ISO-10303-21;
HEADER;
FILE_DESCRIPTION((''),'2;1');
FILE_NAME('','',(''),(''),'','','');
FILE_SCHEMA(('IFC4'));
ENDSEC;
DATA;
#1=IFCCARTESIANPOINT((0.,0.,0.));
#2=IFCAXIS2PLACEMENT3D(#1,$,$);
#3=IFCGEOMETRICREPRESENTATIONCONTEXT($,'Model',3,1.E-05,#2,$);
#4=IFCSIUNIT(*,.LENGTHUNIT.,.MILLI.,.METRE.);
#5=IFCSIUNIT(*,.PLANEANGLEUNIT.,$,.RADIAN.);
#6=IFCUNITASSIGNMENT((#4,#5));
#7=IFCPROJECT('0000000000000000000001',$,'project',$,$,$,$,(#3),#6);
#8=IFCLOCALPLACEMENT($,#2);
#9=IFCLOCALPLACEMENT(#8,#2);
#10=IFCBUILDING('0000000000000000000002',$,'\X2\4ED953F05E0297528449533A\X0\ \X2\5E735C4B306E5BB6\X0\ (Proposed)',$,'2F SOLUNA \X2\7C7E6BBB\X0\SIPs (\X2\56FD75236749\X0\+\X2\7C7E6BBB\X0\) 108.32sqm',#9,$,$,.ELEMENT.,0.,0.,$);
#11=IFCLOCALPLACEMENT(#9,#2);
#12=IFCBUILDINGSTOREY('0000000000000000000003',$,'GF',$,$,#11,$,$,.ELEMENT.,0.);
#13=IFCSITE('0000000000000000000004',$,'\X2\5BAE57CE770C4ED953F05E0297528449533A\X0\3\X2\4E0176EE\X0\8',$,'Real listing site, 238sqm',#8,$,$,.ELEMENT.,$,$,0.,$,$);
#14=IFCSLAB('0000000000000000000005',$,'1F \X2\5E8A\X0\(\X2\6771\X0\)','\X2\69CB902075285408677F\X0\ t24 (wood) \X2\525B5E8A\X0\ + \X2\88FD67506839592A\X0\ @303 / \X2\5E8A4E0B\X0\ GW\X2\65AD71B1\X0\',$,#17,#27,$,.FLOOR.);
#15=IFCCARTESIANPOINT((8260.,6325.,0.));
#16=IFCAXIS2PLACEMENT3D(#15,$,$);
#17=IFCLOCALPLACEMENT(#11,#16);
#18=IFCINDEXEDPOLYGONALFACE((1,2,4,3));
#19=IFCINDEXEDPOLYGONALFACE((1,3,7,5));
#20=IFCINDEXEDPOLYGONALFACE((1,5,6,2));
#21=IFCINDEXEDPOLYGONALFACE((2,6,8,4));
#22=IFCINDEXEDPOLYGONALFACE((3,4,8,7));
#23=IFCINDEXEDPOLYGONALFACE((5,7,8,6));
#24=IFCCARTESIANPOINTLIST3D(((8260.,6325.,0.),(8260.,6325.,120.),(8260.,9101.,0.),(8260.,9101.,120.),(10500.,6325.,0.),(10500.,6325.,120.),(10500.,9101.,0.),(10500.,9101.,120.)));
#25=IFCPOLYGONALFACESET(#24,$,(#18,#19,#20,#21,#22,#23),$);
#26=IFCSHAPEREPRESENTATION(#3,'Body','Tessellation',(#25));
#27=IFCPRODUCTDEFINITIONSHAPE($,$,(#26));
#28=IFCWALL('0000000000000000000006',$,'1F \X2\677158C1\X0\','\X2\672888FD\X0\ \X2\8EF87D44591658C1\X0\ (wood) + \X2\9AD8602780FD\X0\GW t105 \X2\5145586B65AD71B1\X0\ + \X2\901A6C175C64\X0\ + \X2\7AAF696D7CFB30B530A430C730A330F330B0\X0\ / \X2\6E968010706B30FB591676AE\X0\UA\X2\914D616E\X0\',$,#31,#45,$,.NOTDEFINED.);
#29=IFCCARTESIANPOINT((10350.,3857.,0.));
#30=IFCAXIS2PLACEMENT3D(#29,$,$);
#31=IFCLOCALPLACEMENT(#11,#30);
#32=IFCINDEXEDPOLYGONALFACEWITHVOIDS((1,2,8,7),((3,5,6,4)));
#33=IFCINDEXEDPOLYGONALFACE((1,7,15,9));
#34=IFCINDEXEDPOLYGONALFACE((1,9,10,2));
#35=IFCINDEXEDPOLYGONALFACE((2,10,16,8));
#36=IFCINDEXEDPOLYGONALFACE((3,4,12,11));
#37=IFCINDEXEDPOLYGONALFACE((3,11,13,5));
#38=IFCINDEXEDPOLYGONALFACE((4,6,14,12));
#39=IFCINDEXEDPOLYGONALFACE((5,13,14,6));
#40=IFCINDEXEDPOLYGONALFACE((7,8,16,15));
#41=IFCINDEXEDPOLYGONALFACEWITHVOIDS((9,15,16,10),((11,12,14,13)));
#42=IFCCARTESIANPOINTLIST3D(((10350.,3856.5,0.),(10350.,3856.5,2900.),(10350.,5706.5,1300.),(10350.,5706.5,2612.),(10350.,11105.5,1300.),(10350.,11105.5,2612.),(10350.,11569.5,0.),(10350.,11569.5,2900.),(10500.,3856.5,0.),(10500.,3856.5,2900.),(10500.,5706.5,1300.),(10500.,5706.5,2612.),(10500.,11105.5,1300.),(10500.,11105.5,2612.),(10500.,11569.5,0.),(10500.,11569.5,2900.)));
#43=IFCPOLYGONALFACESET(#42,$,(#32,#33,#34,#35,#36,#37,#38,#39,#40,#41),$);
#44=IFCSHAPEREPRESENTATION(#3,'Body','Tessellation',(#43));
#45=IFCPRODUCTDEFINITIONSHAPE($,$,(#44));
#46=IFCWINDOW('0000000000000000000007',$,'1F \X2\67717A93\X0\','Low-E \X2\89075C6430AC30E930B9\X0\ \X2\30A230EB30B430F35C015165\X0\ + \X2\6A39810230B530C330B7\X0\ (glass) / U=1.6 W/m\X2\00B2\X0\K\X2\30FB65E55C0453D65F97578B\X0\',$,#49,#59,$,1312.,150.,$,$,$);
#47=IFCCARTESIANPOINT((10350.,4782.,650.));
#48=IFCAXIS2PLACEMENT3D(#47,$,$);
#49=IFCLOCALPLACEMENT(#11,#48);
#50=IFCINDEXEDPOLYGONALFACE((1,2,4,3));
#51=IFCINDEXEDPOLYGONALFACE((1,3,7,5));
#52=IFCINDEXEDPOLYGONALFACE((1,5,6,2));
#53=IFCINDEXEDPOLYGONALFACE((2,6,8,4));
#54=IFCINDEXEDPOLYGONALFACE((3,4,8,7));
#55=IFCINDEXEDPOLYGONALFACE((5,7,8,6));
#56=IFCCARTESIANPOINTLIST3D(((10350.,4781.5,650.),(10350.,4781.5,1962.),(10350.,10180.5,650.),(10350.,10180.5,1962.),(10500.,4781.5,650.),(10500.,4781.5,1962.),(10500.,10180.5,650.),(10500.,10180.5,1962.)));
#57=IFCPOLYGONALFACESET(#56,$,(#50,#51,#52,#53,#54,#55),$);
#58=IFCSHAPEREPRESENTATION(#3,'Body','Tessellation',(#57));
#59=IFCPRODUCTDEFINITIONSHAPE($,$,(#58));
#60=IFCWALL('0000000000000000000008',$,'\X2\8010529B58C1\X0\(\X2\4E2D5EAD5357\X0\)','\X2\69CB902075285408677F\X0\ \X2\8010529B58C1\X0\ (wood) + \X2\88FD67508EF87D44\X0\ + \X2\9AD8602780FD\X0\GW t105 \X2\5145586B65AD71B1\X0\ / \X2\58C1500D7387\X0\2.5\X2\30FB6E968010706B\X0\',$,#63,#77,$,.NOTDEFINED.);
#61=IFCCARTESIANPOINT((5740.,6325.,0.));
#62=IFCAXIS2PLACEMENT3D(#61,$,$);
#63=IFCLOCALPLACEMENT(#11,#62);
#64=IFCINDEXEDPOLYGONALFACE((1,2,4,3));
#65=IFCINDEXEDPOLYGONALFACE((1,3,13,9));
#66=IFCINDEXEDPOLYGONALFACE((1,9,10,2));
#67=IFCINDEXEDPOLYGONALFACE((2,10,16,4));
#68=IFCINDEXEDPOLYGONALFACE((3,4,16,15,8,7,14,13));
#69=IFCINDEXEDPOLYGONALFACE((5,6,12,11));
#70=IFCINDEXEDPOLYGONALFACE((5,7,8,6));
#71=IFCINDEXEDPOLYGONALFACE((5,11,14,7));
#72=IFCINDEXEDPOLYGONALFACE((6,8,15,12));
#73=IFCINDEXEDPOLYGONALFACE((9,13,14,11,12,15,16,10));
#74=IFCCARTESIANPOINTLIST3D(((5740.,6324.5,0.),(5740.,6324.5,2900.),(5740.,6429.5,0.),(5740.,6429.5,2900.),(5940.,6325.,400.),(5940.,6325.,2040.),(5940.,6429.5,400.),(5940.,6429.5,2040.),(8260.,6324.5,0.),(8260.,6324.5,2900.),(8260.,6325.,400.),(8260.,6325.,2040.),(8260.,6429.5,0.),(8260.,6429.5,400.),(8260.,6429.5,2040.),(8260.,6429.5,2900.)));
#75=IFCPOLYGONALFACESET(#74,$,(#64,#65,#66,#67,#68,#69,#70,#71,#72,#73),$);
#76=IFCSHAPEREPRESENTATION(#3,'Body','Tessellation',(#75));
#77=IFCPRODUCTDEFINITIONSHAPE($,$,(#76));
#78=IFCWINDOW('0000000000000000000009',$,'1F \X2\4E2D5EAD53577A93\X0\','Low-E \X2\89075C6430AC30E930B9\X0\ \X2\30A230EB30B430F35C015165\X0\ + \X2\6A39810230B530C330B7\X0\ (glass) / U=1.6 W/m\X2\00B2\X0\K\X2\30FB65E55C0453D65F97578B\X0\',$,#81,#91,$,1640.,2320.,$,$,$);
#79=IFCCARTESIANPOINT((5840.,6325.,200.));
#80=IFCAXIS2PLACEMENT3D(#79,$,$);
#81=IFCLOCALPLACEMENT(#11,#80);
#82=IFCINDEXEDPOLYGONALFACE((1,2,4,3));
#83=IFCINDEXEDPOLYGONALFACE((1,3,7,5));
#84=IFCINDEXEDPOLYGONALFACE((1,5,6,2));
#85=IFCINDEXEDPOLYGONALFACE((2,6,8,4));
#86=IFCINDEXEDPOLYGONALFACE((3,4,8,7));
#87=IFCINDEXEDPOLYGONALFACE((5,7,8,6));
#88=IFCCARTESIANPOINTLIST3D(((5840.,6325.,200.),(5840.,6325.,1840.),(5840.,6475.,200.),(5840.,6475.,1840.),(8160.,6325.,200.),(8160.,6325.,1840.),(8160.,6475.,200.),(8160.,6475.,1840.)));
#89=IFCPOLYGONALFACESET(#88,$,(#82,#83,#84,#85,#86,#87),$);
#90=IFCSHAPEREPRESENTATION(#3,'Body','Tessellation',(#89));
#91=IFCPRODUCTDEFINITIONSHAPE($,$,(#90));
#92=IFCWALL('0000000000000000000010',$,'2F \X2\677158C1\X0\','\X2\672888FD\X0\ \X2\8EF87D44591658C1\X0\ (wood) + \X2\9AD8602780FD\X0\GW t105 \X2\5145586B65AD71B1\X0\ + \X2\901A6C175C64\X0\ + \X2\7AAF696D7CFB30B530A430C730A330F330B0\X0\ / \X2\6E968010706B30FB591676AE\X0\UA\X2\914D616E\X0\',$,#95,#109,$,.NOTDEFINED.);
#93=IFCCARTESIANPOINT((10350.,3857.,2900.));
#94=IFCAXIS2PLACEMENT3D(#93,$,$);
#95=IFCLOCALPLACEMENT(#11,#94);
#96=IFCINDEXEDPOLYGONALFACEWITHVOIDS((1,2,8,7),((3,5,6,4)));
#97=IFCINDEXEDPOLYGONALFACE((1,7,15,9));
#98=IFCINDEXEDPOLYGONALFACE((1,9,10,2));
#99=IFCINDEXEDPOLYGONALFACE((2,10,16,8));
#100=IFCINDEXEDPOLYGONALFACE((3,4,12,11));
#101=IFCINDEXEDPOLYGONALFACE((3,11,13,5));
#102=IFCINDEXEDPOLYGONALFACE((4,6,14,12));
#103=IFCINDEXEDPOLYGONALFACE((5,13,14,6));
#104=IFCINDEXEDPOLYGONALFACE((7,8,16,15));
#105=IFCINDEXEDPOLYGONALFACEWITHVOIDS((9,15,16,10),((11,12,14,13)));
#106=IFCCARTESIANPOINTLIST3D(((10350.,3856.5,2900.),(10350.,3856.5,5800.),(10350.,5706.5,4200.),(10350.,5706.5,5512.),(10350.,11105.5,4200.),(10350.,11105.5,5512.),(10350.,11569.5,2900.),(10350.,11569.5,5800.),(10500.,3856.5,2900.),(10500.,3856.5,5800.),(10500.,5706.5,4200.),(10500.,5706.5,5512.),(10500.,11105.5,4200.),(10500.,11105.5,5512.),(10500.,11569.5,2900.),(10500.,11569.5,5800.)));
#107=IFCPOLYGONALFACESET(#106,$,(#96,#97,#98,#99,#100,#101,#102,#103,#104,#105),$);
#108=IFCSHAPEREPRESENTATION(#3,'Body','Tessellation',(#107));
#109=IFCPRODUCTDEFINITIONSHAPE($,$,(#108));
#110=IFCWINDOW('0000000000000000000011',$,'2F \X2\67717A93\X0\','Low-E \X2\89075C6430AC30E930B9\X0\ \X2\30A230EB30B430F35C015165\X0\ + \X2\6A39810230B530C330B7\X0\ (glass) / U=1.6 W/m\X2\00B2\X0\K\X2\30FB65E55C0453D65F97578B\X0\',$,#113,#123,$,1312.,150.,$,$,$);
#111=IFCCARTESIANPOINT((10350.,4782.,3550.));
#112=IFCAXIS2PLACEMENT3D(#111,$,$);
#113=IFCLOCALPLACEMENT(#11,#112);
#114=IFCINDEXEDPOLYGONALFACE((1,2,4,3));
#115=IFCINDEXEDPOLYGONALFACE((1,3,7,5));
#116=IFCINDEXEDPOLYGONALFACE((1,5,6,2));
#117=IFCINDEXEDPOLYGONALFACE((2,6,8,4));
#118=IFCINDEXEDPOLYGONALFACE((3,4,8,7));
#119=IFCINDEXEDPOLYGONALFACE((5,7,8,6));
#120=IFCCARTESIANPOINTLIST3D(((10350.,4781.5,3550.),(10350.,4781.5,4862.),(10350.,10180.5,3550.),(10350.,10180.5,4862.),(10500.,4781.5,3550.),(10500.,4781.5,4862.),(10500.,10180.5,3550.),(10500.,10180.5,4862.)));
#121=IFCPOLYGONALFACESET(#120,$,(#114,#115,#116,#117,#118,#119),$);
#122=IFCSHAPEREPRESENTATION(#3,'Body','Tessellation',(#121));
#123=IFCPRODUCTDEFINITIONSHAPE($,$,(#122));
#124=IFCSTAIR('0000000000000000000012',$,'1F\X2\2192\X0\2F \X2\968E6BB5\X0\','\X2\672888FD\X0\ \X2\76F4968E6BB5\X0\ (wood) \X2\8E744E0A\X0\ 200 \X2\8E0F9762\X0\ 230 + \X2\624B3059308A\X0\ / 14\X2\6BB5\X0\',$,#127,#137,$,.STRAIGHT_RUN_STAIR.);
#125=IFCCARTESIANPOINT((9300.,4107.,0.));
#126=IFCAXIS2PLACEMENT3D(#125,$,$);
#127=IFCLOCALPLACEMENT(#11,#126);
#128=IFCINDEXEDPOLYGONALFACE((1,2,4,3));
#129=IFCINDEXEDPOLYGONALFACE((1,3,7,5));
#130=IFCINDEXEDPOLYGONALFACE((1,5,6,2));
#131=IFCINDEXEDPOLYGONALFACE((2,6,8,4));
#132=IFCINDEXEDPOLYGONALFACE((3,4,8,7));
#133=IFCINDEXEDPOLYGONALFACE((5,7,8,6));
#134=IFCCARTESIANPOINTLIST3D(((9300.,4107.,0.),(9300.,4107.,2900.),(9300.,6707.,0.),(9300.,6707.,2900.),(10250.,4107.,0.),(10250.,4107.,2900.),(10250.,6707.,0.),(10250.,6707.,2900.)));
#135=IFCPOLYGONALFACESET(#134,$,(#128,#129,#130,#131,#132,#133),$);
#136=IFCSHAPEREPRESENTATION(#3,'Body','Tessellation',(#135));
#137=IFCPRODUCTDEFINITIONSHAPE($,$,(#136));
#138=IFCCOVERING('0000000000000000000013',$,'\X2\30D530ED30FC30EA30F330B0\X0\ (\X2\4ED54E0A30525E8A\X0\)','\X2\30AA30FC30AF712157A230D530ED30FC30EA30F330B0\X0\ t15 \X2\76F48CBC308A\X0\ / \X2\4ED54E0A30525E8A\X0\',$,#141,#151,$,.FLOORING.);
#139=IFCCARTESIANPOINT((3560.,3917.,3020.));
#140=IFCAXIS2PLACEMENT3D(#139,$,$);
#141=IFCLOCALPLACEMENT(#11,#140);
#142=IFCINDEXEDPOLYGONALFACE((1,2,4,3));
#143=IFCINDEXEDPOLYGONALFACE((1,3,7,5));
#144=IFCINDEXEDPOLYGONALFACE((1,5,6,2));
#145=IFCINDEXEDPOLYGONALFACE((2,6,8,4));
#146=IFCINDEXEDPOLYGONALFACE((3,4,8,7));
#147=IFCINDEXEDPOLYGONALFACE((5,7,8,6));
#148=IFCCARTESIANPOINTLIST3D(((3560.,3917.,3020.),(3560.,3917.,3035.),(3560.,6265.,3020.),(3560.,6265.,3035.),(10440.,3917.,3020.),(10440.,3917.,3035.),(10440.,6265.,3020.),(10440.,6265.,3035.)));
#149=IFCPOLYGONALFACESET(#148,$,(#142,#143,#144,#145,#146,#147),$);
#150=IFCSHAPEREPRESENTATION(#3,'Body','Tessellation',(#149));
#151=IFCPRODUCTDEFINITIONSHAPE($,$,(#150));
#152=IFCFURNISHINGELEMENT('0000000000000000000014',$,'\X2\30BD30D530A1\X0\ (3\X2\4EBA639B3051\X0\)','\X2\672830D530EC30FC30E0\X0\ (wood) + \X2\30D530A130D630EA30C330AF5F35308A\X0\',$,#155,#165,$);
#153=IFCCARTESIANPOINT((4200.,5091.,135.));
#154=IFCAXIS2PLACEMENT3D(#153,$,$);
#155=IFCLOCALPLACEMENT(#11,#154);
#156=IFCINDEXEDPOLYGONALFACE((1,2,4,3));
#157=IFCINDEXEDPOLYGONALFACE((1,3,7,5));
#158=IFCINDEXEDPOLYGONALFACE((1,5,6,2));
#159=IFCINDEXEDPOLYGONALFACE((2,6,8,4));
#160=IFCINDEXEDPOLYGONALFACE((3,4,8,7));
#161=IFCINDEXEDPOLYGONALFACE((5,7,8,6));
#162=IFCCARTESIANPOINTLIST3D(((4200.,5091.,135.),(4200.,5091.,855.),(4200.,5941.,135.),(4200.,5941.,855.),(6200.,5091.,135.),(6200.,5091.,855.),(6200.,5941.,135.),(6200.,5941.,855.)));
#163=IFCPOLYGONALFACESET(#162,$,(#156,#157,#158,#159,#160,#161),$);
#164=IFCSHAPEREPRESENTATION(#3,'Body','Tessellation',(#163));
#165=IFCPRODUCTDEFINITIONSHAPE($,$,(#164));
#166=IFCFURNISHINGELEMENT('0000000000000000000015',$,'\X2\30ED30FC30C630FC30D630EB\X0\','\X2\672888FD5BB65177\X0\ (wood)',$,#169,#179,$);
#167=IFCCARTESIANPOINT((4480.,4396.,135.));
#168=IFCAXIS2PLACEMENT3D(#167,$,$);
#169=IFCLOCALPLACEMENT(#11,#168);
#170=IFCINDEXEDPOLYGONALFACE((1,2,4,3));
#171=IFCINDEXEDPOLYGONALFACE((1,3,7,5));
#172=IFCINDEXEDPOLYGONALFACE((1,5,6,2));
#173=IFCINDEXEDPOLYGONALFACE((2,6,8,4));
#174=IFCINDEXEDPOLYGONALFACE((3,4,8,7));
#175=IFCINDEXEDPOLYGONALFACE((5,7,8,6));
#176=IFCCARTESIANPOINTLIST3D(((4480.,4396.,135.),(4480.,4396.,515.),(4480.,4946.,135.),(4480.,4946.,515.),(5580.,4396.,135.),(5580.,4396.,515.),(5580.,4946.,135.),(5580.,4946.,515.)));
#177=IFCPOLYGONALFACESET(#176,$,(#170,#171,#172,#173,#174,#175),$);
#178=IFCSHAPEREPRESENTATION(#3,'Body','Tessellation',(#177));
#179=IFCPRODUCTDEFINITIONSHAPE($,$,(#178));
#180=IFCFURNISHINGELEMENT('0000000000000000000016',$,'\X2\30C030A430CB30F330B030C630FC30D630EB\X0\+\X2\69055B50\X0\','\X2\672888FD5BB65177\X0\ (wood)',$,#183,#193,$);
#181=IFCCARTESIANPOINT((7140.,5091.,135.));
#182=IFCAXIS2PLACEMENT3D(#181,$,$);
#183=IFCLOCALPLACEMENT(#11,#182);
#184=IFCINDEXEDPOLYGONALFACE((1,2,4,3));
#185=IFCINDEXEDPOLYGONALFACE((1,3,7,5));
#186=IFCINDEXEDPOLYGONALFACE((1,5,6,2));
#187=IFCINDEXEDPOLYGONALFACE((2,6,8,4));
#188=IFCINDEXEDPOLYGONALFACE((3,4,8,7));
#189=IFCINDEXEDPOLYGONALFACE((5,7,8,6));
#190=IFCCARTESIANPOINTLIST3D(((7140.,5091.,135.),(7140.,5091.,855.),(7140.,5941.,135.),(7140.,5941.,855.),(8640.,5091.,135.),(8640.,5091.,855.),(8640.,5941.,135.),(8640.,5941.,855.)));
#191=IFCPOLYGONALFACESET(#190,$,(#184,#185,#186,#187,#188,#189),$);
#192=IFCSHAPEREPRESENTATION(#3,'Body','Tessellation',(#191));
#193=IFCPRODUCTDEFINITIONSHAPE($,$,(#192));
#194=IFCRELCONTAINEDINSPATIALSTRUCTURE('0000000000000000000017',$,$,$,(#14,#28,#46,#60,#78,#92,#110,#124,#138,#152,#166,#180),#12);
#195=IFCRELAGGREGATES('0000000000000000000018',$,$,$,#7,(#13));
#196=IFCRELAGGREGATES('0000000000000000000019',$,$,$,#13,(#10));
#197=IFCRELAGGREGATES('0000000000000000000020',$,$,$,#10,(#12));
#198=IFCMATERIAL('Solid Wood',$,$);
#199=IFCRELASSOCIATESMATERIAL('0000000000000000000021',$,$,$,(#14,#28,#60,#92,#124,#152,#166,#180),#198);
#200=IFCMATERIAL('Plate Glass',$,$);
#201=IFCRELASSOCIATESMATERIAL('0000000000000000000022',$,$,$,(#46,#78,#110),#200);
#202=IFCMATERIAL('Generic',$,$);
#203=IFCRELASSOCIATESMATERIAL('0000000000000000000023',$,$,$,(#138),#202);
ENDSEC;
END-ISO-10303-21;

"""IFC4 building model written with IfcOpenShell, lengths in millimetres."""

from ifc_helpers import new_model, si_unit, frame, frame_2d, origin, place, context, project, spatial, rectangle, extrude, material, element, fill, save


model = new_model("IFC4")

# Units and contexts
model_context = context("Model", 3, precision=1e-05, world=origin())
ifc_project = project(units=[si_unit("LENGTHUNIT", "METRE", prefix="MILLI"), si_unit("PLANEANGLEUNIT", "RADIAN")], contexts=[model_context])

# Site, building, storey
site_placement = place(None, origin())
site = spatial("IfcSite", under=ifc_project, at=site_placement, Name="宮城県仙台市青葉区3丁目8", ObjectType="Real listing site, 238sqm", CompositionType="ELEMENT", RefElevation=0.0)
building_placement = place(site_placement, origin())
building = spatial("IfcBuilding", under=site, at=building_placement, Name="仙台市青葉区 平屋の家 (Proposed)", ObjectType="2F SOLUNA 籾殻SIPs (国産杉+籾殻) 108.32sqm", CompositionType="ELEMENT", ElevationOfRefHeight=0.0, ElevationOfTerrain=0.0)
storey_placement = place(building_placement, origin())
storey = spatial("IfcBuildingStorey", under=building, at=storey_placement, Name="GF", CompositionType="ELEMENT", Elevation=0.0)

# Slab
ifc_material_1 = material(Name="Solid Wood")
slab_placement = place(storey_placement, frame((8260.0, 6325.0, 0.0)))
element("IfcSlab", 1, at=slab_placement, inside=storey, material=ifc_material_1, Name="1F 床(東)", Description="構造用合板 t24 (wood) 剛床 + 製材根太 @303 / 床下 GW断熱", PredefinedType="FLOOR", context=model_context, shape_type="SweptSolid", body=[
    extrude(rectangle(XDim=2240.0, YDim=2776.0, at=frame_2d((1120.0, 1388.0))), frame((8260.0, 6325.0, 0.0)), (0.0, 0.0, 1.0), 120.0),
])

# Walls, openings, windows
wall_1_placement = place(storey_placement, frame((10350.0, 3857.0, 0.0)))
wall_1 = element("IfcWall", 2, at=wall_1_placement, inside=storey, material=ifc_material_1, Name="1F 東壁", Description="木製 軸組外壁 (wood) + 高性能GW t105 充填断熱 + 通気層 + 窯業系サイディング / 準耐火・外皮UA配慮", PredefinedType="NOTDEFINED", context=model_context, shape_type="SweptSolid", body=[
    extrude(rectangle(XDim=150.0, YDim=7713.0, at=frame_2d((75.0, 3856.0))), frame((10350.0, 3857.0, 0.0)), (0.0, 0.0, 1.0), 2900.0),
])
opening_1_placement = place(storey_placement, frame((10350.0, 4782.0, 650.0)))
opening_1 = element("IfcOpeningElement", 3, at=opening_1_placement, cuts=wall_1, PredefinedType="NOTDEFINED", context=model_context, shape_type="SweptSolid", body=[
    extrude(rectangle(XDim=150.0, YDim=5399.0, at=frame_2d((75.0, 2699.0))), frame((10350.0, 4782.0, 650.0)), (0.0, 0.0, 1.0), 1312.0),
])
ifc_material_2 = material(Name="Plate Glass")
window_1_placement = place(storey_placement, frame((10350.0, 4782.0, 650.0)))
window_1 = element("IfcWindow", 4, at=window_1_placement, inside=storey, material=ifc_material_2, Name="1F 東窓", Description="Low-E 複層ガラス アルゴン封入 + 樹脂サッシ (glass) / U=1.6 W/m²K・日射取得型", OverallHeight=1312.0, OverallWidth=150.0, context=model_context, shape_type="SweptSolid", body=[
    extrude(rectangle(XDim=150.0, YDim=5399.0, at=frame_2d((75.0, 2699.0))), frame((10350.0, 4782.0, 650.0)), (0.0, 0.0, 1.0), 1312.0),
])
fill(opening_1, window_1)
wall_2_placement = place(storey_placement, frame((5740.0, 6325.0, 0.0)))
wall_2 = element("IfcWall", 5, at=wall_2_placement, inside=storey, material=ifc_material_1, Name="耐力壁(中庭南)", Description="構造用合板 耐力壁 (wood) + 製材軸組 + 高性能GW t105 充填断熱 / 壁倍率2.5・準耐火", PredefinedType="NOTDEFINED", context=model_context, shape_type="SweptSolid", body=[
    extrude(rectangle(XDim=2520.0, YDim=105.0, at=frame_2d((1260.0, 52.0))), frame((5740.0, 6325.0, 0.0)), (0.0, 0.0, 1.0), 2900.0),
])
opening_2_placement = place(storey_placement, frame((5840.0, 6325.0, 200.0)))
opening_2 = element("IfcOpeningElement", 6, at=opening_2_placement, cuts=wall_2, PredefinedType="NOTDEFINED", context=model_context, shape_type="SweptSolid", body=[
    extrude(rectangle(XDim=2320.0, YDim=150.0, at=frame_2d((1160.0, 75.0))), frame((5840.0, 6325.0, 200.0)), (0.0, 0.0, 1.0), 1640.0),
])
window_2_placement = place(storey_placement, frame((5840.0, 6325.0, 200.0)))
window_2 = element("IfcWindow", 7, at=window_2_placement, inside=storey, material=ifc_material_2, Name="1F 中庭南窓", Description="Low-E 複層ガラス アルゴン封入 + 樹脂サッシ (glass) / U=1.6 W/m²K・日射取得型", OverallHeight=1640.0, OverallWidth=2320.0, context=model_context, shape_type="SweptSolid", body=[
    extrude(rectangle(XDim=2320.0, YDim=150.0, at=frame_2d((1160.0, 75.0))), frame((5840.0, 6325.0, 200.0)), (0.0, 0.0, 1.0), 1640.0),
])
fill(opening_2, window_2)

# Wall, opening, window
wall_3_placement = place(storey_placement, frame((10350.0, 3857.0, 2900.0)))
wall_3 = element("IfcWall", 8, at=wall_3_placement, inside=storey, material=ifc_material_1, Name="2F 東壁", Description="木製 軸組外壁 (wood) + 高性能GW t105 充填断熱 + 通気層 + 窯業系サイディング / 準耐火・外皮UA配慮", PredefinedType="NOTDEFINED", context=model_context, shape_type="SweptSolid", body=[
    extrude(rectangle(XDim=150.0, YDim=7713.0, at=frame_2d((75.0, 3856.0))), frame((10350.0, 3857.0, 2900.0)), (0.0, 0.0, 1.0), 2900.0),
])
opening_3_placement = place(storey_placement, frame((10350.0, 4782.0, 3550.0)))
opening_3 = element("IfcOpeningElement", 9, at=opening_3_placement, cuts=wall_3, PredefinedType="NOTDEFINED", context=model_context, shape_type="SweptSolid", body=[
    extrude(rectangle(XDim=150.0, YDim=5399.0, at=frame_2d((75.0, 2699.0))), frame((10350.0, 4782.0, 3550.0)), (0.0, 0.0, 1.0), 1312.0),
])
window_3_placement = place(storey_placement, frame((10350.0, 4782.0, 3550.0)))
window_3 = element("IfcWindow", 10, at=window_3_placement, inside=storey, material=ifc_material_2, Name="2F 東窓", Description="Low-E 複層ガラス アルゴン封入 + 樹脂サッシ (glass) / U=1.6 W/m²K・日射取得型", OverallHeight=1312.0, OverallWidth=150.0, context=model_context, shape_type="SweptSolid", body=[
    extrude(rectangle(XDim=150.0, YDim=5399.0, at=frame_2d((75.0, 2699.0))), frame((10350.0, 4782.0, 3550.0)), (0.0, 0.0, 1.0), 1312.0),
])
fill(opening_3, window_3)

# Stair
stair_placement = place(storey_placement, frame((9300.0, 4107.0, 0.0)))
element("IfcStair", 11, at=stair_placement, inside=storey, material=ifc_material_1, Name="1F→2F 階段", Description="木製 直階段 (wood) 蹴上 200 踏面 230 + 手すり / 14段", PredefinedType="STRAIGHT_RUN_STAIR", context=model_context, shape_type="SweptSolid", body=[
    extrude(rectangle(XDim=950.0, YDim=2600.0, at=frame_2d((475.0, 1300.0))), frame((9300.0, 4107.0, 0.0)), (0.0, 0.0, 1.0), 2900.0),
])

# Covering
ifc_material_3 = material(Name="Generic")
covering_placement = place(storey_placement, frame((3560.0, 3917.0, 3020.0)))
element("IfcCovering", 12, at=covering_placement, inside=storey, material=ifc_material_3, Name="フローリング (仕上げ床)", Description="オーク無垢フローリング t15 直貼り / 仕上げ床", PredefinedType="FLOORING", context=model_context, shape_type="SweptSolid", body=[
    extrude(rectangle(XDim=6880.0, YDim=2348.0, at=frame_2d((3440.0, 1174.0))), frame((3560.0, 3917.0, 3020.0)), (0.0, 0.0, 1.0), 15.0),
])

# Furnishing elements
furnishing_1_placement = place(storey_placement, frame((4200.0, 5091.0, 135.0)))
element("IfcFurnishingElement", 13, at=furnishing_1_placement, inside=storey, material=ifc_material_1, Name="ソファ (3人掛け)", Description="木フレーム (wood) + ファブリック張り", context=model_context, shape_type="SweptSolid", body=[
    extrude(rectangle(XDim=2000.0, YDim=850.0, at=frame_2d((1000.0, 425.0))), frame((4200.0, 5091.0, 135.0)), (0.0, 0.0, 1.0), 720.0),
])
furnishing_2_placement = place(storey_placement, frame((4480.0, 4396.0, 135.0)))
element("IfcFurnishingElement", 14, at=furnishing_2_placement, inside=storey, material=ifc_material_1, Name="ローテーブル", Description="木製家具 (wood)", context=model_context, shape_type="SweptSolid", body=[
    extrude(rectangle(XDim=1100.0, YDim=550.0, at=frame_2d((550.0, 275.0))), frame((4480.0, 4396.0, 135.0)), (0.0, 0.0, 1.0), 380.0),
])
furnishing_3_placement = place(storey_placement, frame((7140.0, 5091.0, 135.0)))
element("IfcFurnishingElement", 15, at=furnishing_3_placement, inside=storey, material=ifc_material_1, Name="ダイニングテーブル+椅子", Description="木製家具 (wood)", context=model_context, shape_type="SweptSolid", body=[
    extrude(rectangle(XDim=1500.0, YDim=850.0, at=frame_2d((750.0, 425.0))), frame((7140.0, 5091.0, 135.0)), (0.0, 0.0, 1.0), 720.0),
])

save(model, "model.ifc")
